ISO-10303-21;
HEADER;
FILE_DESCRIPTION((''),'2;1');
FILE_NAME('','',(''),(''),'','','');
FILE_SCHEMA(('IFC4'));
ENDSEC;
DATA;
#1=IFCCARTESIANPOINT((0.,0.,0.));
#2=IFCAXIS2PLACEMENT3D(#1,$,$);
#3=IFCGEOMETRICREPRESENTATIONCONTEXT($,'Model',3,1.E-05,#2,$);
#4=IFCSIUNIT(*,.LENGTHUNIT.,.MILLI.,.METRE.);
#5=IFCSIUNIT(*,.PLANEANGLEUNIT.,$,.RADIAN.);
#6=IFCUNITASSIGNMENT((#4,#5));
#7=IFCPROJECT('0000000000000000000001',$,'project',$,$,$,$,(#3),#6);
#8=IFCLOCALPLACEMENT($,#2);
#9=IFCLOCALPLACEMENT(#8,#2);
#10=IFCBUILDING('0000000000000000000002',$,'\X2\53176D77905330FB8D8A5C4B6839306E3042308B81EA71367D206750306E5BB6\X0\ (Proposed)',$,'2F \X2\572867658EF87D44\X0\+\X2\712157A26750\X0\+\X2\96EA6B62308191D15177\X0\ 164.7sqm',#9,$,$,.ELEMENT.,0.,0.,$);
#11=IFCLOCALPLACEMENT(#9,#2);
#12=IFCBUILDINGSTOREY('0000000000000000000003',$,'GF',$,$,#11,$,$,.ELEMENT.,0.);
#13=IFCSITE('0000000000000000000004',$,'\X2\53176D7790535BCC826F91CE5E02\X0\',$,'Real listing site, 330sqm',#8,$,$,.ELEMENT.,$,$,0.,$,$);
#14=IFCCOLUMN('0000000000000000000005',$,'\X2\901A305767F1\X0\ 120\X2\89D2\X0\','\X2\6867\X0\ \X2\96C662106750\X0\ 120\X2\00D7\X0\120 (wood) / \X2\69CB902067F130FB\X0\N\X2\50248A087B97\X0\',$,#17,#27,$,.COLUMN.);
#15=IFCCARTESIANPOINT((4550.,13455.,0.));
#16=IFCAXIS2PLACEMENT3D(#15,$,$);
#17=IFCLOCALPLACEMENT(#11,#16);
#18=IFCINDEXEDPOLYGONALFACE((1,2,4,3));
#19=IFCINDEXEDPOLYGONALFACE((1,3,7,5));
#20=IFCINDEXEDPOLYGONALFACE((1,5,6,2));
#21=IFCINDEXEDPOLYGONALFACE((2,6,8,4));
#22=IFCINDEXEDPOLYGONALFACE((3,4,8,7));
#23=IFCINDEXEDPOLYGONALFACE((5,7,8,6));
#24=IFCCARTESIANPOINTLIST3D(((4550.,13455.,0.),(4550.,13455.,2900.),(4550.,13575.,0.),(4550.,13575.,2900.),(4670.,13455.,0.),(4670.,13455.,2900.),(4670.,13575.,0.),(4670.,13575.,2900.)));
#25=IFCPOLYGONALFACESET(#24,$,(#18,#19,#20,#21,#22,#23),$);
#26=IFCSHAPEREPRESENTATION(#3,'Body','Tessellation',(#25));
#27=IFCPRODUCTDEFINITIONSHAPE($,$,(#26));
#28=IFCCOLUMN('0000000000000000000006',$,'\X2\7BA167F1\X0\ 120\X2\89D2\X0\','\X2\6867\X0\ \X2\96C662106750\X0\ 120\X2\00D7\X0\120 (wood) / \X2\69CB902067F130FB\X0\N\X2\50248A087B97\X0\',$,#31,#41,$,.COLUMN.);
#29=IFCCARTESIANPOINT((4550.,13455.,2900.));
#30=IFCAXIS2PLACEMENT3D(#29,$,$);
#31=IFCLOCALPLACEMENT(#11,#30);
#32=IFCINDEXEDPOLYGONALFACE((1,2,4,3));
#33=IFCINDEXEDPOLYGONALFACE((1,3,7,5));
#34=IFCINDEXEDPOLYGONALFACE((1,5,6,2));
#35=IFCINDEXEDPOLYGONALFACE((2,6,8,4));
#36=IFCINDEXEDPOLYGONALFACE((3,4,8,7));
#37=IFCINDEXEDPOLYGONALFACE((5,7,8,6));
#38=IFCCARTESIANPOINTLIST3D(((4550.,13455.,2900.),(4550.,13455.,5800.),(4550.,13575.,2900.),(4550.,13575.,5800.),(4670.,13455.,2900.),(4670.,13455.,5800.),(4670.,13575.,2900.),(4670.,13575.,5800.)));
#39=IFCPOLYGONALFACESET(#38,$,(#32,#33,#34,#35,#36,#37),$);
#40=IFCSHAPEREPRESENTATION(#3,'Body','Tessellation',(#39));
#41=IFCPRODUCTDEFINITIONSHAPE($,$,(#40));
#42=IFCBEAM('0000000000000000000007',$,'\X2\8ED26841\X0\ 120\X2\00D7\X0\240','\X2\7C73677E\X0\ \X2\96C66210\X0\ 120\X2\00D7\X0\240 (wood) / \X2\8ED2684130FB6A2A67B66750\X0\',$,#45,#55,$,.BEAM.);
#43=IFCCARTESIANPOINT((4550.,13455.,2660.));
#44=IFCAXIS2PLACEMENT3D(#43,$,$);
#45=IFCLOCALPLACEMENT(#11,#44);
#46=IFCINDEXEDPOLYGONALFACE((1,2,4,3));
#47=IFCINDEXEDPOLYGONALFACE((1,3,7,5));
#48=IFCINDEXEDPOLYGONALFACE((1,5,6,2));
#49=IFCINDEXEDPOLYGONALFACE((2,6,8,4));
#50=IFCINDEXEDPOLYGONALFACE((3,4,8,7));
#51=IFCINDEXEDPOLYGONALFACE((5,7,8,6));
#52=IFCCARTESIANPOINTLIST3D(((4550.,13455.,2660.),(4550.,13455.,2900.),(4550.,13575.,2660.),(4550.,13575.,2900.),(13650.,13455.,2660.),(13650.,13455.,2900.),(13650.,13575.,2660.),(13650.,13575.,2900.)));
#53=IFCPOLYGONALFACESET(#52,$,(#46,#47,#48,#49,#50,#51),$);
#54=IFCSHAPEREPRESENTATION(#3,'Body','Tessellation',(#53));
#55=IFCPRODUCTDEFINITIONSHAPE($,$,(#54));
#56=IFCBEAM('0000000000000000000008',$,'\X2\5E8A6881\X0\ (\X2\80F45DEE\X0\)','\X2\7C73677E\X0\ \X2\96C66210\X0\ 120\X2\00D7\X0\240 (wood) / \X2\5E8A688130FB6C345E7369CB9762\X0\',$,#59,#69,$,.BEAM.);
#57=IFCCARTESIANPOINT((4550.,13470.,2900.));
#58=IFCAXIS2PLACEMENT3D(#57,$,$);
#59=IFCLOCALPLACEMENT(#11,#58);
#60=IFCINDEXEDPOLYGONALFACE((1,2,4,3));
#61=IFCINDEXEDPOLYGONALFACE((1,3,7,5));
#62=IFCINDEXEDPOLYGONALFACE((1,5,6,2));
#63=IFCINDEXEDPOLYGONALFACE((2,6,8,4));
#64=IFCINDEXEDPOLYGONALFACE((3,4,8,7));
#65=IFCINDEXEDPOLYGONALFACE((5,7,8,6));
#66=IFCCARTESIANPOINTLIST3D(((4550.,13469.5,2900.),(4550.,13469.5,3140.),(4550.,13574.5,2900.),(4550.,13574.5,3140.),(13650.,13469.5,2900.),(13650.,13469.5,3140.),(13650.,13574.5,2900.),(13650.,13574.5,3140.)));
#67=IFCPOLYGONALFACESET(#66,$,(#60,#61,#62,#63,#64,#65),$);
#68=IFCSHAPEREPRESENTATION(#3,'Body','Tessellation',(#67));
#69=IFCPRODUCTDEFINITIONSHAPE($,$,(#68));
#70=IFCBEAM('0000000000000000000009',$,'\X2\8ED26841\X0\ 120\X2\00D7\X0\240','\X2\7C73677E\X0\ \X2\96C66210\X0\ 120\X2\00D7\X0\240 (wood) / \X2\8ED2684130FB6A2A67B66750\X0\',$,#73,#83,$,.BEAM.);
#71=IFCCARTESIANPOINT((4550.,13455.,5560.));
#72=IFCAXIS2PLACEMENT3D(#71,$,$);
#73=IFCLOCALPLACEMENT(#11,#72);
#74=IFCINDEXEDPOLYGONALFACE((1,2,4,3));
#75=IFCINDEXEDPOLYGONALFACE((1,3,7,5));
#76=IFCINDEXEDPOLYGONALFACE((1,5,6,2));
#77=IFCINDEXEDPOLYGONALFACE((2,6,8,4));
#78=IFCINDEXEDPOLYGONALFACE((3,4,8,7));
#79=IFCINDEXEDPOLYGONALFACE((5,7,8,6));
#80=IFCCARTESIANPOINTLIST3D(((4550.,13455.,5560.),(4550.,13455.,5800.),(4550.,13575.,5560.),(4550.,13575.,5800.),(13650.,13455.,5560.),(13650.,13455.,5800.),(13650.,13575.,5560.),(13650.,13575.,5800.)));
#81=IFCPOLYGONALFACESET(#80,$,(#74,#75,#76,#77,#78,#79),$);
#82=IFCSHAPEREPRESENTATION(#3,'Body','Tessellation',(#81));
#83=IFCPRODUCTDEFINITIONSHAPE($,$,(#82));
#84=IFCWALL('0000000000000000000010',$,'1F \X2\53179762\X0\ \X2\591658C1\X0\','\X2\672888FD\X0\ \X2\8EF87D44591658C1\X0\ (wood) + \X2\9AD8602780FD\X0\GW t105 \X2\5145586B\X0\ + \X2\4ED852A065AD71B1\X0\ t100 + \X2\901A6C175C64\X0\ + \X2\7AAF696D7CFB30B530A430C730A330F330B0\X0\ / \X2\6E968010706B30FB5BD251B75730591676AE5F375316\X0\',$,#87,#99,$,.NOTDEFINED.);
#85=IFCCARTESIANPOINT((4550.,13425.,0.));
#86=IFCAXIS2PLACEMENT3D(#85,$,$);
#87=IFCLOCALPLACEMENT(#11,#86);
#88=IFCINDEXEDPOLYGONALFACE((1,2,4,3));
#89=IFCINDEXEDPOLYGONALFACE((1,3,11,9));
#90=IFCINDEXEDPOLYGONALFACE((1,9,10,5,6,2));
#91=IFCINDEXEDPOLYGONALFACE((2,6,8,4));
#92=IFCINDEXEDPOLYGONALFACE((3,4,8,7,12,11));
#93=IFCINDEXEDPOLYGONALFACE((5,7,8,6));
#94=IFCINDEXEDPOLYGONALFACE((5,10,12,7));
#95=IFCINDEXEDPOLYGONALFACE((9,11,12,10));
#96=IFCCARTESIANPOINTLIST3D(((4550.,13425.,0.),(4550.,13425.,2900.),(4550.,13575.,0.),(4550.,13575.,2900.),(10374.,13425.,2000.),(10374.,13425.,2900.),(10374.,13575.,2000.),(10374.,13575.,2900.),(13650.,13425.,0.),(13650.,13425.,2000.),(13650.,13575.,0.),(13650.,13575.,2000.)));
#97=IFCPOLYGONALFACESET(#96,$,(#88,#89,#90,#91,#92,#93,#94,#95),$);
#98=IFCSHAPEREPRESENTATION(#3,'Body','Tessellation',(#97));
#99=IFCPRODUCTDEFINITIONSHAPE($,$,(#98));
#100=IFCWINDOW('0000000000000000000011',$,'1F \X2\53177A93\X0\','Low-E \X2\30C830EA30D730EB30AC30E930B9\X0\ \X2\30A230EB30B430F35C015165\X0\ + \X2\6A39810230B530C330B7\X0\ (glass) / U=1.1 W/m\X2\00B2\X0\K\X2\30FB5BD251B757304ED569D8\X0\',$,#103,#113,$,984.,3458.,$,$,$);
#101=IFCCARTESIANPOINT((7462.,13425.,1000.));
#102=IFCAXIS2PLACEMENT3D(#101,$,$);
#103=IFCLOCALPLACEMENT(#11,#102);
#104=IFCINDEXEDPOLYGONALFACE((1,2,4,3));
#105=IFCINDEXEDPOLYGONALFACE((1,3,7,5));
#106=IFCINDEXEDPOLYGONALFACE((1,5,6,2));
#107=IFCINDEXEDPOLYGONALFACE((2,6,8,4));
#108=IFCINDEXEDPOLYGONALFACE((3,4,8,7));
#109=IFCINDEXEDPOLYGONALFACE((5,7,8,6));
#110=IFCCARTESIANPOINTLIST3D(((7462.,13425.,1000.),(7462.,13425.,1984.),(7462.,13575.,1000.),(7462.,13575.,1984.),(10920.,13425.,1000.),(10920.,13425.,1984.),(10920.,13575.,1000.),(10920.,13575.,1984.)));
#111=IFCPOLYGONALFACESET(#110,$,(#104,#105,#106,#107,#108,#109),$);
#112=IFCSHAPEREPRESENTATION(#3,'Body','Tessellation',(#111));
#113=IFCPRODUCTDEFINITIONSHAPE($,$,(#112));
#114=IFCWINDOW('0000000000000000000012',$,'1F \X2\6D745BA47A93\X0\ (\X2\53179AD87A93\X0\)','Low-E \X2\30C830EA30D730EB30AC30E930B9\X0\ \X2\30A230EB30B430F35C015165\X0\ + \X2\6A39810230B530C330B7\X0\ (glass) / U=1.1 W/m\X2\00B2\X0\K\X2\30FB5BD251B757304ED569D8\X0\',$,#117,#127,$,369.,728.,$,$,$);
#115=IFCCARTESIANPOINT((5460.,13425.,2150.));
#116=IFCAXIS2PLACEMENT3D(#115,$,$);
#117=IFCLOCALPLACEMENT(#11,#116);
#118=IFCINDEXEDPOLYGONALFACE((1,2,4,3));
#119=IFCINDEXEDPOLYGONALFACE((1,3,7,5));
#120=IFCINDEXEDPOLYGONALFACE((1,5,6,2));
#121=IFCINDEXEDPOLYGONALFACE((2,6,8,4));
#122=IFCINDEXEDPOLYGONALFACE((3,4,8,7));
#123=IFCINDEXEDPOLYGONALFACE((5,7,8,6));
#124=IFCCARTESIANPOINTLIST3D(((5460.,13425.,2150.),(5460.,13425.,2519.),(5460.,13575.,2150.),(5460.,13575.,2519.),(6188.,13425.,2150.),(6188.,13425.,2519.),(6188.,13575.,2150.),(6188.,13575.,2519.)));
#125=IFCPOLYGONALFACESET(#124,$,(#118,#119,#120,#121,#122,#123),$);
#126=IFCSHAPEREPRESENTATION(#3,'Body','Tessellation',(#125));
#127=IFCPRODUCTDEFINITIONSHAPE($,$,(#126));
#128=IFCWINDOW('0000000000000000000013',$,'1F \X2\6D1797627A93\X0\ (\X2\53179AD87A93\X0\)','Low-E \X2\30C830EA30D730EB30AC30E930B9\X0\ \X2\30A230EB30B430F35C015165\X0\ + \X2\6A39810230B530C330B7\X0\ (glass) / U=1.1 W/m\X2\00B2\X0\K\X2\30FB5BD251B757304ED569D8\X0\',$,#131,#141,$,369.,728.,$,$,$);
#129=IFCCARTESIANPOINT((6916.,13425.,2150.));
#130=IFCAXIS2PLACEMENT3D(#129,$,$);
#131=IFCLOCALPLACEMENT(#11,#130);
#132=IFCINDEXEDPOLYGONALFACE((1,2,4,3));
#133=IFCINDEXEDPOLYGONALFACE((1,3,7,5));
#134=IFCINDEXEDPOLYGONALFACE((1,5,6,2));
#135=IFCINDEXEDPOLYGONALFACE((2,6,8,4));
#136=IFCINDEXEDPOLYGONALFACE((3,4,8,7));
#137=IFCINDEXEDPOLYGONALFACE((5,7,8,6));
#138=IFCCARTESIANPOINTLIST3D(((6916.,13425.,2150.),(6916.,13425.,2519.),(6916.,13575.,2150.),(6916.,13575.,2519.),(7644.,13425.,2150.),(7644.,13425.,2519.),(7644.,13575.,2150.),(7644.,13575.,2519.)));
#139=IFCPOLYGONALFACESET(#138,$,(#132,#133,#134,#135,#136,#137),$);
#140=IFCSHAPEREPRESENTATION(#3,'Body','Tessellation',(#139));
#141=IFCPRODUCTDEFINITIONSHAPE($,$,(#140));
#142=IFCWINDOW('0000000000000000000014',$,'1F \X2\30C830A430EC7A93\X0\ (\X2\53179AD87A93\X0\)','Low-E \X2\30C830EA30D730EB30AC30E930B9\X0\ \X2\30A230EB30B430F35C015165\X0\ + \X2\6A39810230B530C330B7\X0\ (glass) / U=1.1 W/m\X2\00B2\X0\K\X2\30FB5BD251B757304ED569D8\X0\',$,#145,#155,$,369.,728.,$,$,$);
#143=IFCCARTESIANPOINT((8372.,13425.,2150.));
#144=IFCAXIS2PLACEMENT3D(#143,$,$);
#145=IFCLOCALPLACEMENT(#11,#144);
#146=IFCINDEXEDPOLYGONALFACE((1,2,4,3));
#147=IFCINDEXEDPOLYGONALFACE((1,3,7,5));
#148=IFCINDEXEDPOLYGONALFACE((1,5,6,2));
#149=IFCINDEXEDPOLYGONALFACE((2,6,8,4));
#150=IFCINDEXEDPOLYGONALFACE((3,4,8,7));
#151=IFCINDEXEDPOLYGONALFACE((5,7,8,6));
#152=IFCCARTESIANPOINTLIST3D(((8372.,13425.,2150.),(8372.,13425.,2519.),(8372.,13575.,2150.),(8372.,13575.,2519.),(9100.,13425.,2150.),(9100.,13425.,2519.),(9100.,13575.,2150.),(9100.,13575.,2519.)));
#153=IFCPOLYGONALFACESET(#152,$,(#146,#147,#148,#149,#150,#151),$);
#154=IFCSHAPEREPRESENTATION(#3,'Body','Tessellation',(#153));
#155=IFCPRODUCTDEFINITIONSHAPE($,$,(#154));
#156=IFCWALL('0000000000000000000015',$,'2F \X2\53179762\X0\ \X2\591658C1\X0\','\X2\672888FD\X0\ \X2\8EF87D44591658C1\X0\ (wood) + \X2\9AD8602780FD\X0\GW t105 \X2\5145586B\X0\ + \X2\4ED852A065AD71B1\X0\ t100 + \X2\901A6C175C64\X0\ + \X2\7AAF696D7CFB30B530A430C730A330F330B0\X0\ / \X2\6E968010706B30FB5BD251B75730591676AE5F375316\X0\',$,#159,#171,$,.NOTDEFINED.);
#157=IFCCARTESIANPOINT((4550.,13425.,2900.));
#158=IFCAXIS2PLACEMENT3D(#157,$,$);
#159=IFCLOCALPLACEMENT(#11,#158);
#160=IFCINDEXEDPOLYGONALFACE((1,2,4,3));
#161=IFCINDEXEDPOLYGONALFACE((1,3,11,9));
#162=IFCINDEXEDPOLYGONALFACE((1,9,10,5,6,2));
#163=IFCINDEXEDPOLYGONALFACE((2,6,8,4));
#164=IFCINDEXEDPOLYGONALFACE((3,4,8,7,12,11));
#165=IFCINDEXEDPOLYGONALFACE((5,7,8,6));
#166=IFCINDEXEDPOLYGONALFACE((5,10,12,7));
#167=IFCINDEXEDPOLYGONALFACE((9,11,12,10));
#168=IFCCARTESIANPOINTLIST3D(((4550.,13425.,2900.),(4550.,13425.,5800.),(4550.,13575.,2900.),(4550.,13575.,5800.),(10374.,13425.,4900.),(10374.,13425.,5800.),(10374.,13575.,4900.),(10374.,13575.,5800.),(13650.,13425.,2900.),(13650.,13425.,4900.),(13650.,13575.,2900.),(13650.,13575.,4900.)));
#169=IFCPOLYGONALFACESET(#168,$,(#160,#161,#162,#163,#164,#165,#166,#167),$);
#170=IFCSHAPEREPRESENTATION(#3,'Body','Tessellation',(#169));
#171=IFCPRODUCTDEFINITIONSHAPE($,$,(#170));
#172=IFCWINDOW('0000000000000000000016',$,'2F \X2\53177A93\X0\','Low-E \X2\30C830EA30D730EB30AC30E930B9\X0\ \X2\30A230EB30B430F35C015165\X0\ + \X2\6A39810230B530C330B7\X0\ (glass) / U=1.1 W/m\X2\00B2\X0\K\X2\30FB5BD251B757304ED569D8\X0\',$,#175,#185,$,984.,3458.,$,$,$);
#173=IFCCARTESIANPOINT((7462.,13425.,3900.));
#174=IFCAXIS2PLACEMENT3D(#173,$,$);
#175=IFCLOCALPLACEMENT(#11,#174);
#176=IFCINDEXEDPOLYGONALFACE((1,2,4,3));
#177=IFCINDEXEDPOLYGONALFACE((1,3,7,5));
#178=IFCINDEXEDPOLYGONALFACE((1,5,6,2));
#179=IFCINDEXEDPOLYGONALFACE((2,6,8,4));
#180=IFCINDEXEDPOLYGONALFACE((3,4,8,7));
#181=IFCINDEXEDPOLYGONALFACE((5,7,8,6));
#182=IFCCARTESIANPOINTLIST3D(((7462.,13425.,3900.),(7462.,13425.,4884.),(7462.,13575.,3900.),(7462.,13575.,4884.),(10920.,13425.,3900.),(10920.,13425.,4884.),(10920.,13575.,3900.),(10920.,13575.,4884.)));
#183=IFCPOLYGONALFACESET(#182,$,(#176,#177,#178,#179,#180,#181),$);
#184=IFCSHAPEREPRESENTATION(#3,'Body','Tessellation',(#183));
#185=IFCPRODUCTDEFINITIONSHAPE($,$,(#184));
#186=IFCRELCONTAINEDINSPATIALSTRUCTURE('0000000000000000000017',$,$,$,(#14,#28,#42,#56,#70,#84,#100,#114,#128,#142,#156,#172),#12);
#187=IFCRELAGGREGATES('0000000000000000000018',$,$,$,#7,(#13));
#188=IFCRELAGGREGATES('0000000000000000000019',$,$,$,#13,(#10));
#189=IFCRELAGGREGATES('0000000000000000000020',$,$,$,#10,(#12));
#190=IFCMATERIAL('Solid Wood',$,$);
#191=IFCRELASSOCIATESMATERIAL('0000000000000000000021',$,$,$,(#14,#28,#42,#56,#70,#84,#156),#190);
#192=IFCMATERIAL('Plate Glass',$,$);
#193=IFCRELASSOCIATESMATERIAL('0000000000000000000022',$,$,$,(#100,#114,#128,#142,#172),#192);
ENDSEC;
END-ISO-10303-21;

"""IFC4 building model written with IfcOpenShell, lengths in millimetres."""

from ifc_helpers import new_model, si_unit, frame, frame_2d, origin, place, context, project, spatial, rectangle, extrude, material, element, fill, save


model = new_model("IFC4")

# Units and contexts
model_context = context("Model", 3, precision=1e-05, world=origin())
ifc_project = project(units=[si_unit("LENGTHUNIT", "METRE", prefix="MILLI"), si_unit("PLANEANGLEUNIT", "RADIAN")], contexts=[model_context])

# Site, building, storey
site_placement = place(None, origin())
site = spatial("IfcSite", under=ifc_project, at=site_placement, Name="北海道富良野市", ObjectType="Real listing site, 330sqm", CompositionType="ELEMENT", RefElevation=0.0)
building_placement = place(site_placement, origin())
building = spatial("IfcBuilding", under=site, at=building_placement, Name="北海道・越屋根のある自然素材の家 (Proposed)", ObjectType="2F 在来軸組+無垢材+雪止め金具 164.7sqm", CompositionType="ELEMENT", ElevationOfRefHeight=0.0, ElevationOfTerrain=0.0)
storey_placement = place(building_placement, origin())
storey = spatial("IfcBuildingStorey", under=building, at=storey_placement, Name="GF", CompositionType="ELEMENT", Elevation=0.0)

# Columns
ifc_material_1 = material(Name="Solid Wood")
column_1_placement = place(storey_placement, frame((4550.0, 13455.0, 0.0)))
element("IfcColumn", 1, at=column_1_placement, inside=storey, material=ifc_material_1, Name="通し柱 120角", Description="桧 集成材 120×120 (wood) / 構造柱・N値計算", PredefinedType="COLUMN", context=model_context, shape_type="SweptSolid", body=[
    extrude(rectangle(XDim=120.0, YDim=120.0, at=frame_2d((60.0, 60.0))), frame((4550.0, 13455.0, 0.0)), (0.0, 0.0, 1.0), 2900.0),
])
column_2_placement = place(storey_placement, frame((4550.0, 13455.0, 2900.0)))
element("IfcColumn", 2, at=column_2_placement, inside=storey, material=ifc_material_1, Name="管柱 120角", Description="桧 集成材 120×120 (wood) / 構造柱・N値計算", PredefinedType="COLUMN", context=model_context, shape_type="SweptSolid", body=[
    extrude(rectangle(XDim=120.0, YDim=120.0, at=frame_2d((60.0, 60.0))), frame((4550.0, 13455.0, 2900.0)), (0.0, 0.0, 1.0), 2900.0),
])

# Beams
beam_1_placement = place(storey_placement, frame((4550.0, 13455.0, 2660.0)))
element("IfcBeam", 3, at=beam_1_placement, inside=storey, material=ifc_material_1, Name="軒桁 120×240", Description="米松 集成 120×240 (wood) / 軒桁・横架材", PredefinedType="BEAM", context=model_context, shape_type="SweptSolid", body=[
    extrude(rectangle(XDim=9100.0, YDim=120.0, at=frame_2d((4550.0, 60.0))), frame((4550.0, 13455.0, 2660.0)), (0.0, 0.0, 1.0), 240.0),
])
beam_2_placement = place(storey_placement, frame((4550.0, 13470.0, 2900.0)))
element("IfcBeam", 4, at=beam_2_placement, inside=storey, material=ifc_material_1, Name="床梁 (胴差)", Description="米松 集成 120×240 (wood) / 床梁・水平構面", PredefinedType="BEAM", context=model_context, shape_type="SweptSolid", body=[
    extrude(rectangle(XDim=9100.0, YDim=105.0, at=frame_2d((4550.0, 52.0))), frame((4550.0, 13470.0, 2900.0)), (0.0, 0.0, 1.0), 240.0),
])
beam_3_placement = place(storey_placement, frame((4550.0, 13455.0, 5560.0)))
element("IfcBeam", 5, at=beam_3_placement, inside=storey, material=ifc_material_1, Name="軒桁 120×240", Description="米松 集成 120×240 (wood) / 軒桁・横架材", PredefinedType="BEAM", context=model_context, shape_type="SweptSolid", body=[
    extrude(rectangle(XDim=9100.0, YDim=120.0, at=frame_2d((4550.0, 60.0))), frame((4550.0, 13455.0, 5560.0)), (0.0, 0.0, 1.0), 240.0),
])

# Wall, openings, windows
wall_1_placement = place(storey_placement, frame((4550.0, 13425.0, 0.0)))
wall_1 = element("IfcWall", 6, at=wall_1_placement, inside=storey, material=ifc_material_1, Name="1F 北面 外壁", Description="木製 軸組外壁 (wood) + 高性能GW t105 充填 + 付加断熱 t100 + 通気層 + 窯業系サイディング / 準耐火・寒冷地外皮強化", PredefinedType="NOTDEFINED", context=model_context, shape_type="SweptSolid", body=[
    extrude(rectangle(XDim=9100.0, YDim=150.0, at=frame_2d((4550.0, 75.0))), frame((4550.0, 13425.0, 0.0)), (0.0, 0.0, 1.0), 2900.0),
])
opening_1_placement = place(storey_placement, frame((7462.0, 13425.0, 1000.0)))
opening_1 = element("IfcOpeningElement", 7, at=opening_1_placement, cuts=wall_1, PredefinedType="NOTDEFINED", context=model_context, shape_type="SweptSolid", body=[
    extrude(rectangle(XDim=3458.0, YDim=150.0, at=frame_2d((1729.0, 75.0))), frame((7462.0, 13425.0, 1000.0)), (0.0, 0.0, 1.0), 984.0),
])
opening_2_placement = place(storey_placement, frame((5460.0, 13425.0, 2150.0)))
opening_2 = element("IfcOpeningElement", 8, at=opening_2_placement, cuts=wall_1, PredefinedType="NOTDEFINED", context=model_context, shape_type="SweptSolid", body=[
    extrude(rectangle(XDim=728.0, YDim=150.0, at=frame_2d((364.0, 75.0))), frame((5460.0, 13425.0, 2150.0)), (0.0, 0.0, 1.0), 369.0),
])
opening_3_placement = place(storey_placement, frame((6916.0, 13425.0, 2150.0)))
opening_3 = element("IfcOpeningElement", 9, at=opening_3_placement, cuts=wall_1, PredefinedType="NOTDEFINED", context=model_context, shape_type="SweptSolid", body=[
    extrude(rectangle(XDim=728.0, YDim=150.0, at=frame_2d((364.0, 75.0))), frame((6916.0, 13425.0, 2150.0)), (0.0, 0.0, 1.0), 369.0),
])
opening_4_placement = place(storey_placement, frame((8372.0, 13425.0, 2150.0)))
opening_4 = element("IfcOpeningElement", 10, at=opening_4_placement, cuts=wall_1, PredefinedType="NOTDEFINED", context=model_context, shape_type="SweptSolid", body=[
    extrude(rectangle(XDim=728.0, YDim=150.0, at=frame_2d((364.0, 75.0))), frame((8372.0, 13425.0, 2150.0)), (0.0, 0.0, 1.0), 369.0),
])
ifc_material_2 = material(Name="Plate Glass")
window_1_placement = place(storey_placement, frame((7462.0, 13425.0, 1000.0)))
window_1 = element("IfcWindow", 11, at=window_1_placement, inside=storey, material=ifc_material_2, Name="1F 北窓", Description="Low-E トリプルガラス アルゴン封入 + 樹脂サッシ (glass) / U=1.1 W/m²K・寒冷地仕様", OverallHeight=984.0, OverallWidth=3458.0, context=model_context, shape_type="SweptSolid", body=[
    extrude(rectangle(XDim=3458.0, YDim=150.0, at=frame_2d((1729.0, 75.0))), frame((7462.0, 13425.0, 1000.0)), (0.0, 0.0, 1.0), 984.0),
])
fill(opening_1, window_1)
window_2_placement = place(storey_placement, frame((5460.0, 13425.0, 2150.0)))
window_2 = element("IfcWindow", 12, at=window_2_placement, inside=storey, material=ifc_material_2, Name="1F 浴室窓 (北高窓)", Description="Low-E トリプルガラス アルゴン封入 + 樹脂サッシ (glass) / U=1.1 W/m²K・寒冷地仕様", OverallHeight=369.0, OverallWidth=728.0, context=model_context, shape_type="SweptSolid", body=[
    extrude(rectangle(XDim=728.0, YDim=150.0, at=frame_2d((364.0, 75.0))), frame((5460.0, 13425.0, 2150.0)), (0.0, 0.0, 1.0), 369.0),
])
fill(opening_2, window_2)
window_3_placement = place(storey_placement, frame((6916.0, 13425.0, 2150.0)))
window_3 = element("IfcWindow", 13, at=window_3_placement, inside=storey, material=ifc_material_2, Name="1F 洗面窓 (北高窓)", Description="Low-E トリプルガラス アルゴン封入 + 樹脂サッシ (glass) / U=1.1 W/m²K・寒冷地仕様", OverallHeight=369.0, OverallWidth=728.0, context=model_context, shape_type="SweptSolid", body=[
    extrude(rectangle(XDim=728.0, YDim=150.0, at=frame_2d((364.0, 75.0))), frame((6916.0, 13425.0, 2150.0)), (0.0, 0.0, 1.0), 369.0),
])
fill(opening_3, window_3)
window_4_placement = place(storey_placement, frame((8372.0, 13425.0, 2150.0)))
window_4 = element("IfcWindow", 14, at=window_4_placement, inside=storey, material=ifc_material_2, Name="1F トイレ窓 (北高窓)", Description="Low-E トリプルガラス アルゴン封入 + 樹脂サッシ (glass) / U=1.1 W/m²K・寒冷地仕様", OverallHeight=369.0, OverallWidth=728.0, context=model_context, shape_type="SweptSolid", body=[
    extrude(rectangle(XDim=728.0, YDim=150.0, at=frame_2d((364.0, 75.0))), frame((8372.0, 13425.0, 2150.0)), (0.0, 0.0, 1.0), 369.0),
])
fill(opening_4, window_4)

# Wall, opening, window
wall_2_placement = place(storey_placement, frame((4550.0, 13425.0, 2900.0)))
wall_2 = element("IfcWall", 15, at=wall_2_placement, inside=storey, material=ifc_material_1, Name="2F 北面 外壁", Description="木製 軸組外壁 (wood) + 高性能GW t105 充填 + 付加断熱 t100 + 通気層 + 窯業系サイディング / 準耐火・寒冷地外皮強化", PredefinedType="NOTDEFINED", context=model_context, shape_type="SweptSolid", body=[
    extrude(rectangle(XDim=9100.0, YDim=150.0, at=frame_2d((4550.0, 75.0))), frame((4550.0, 13425.0, 2900.0)), (0.0, 0.0, 1.0), 2900.0),
])
opening_5_placement = place(storey_placement, frame((7462.0, 13425.0, 3900.0)))
opening_5 = element("IfcOpeningElement", 16, at=opening_5_placement, cuts=wall_2, PredefinedType="NOTDEFINED", context=model_context, shape_type="SweptSolid", body=[
    extrude(rectangle(XDim=3458.0, YDim=150.0, at=frame_2d((1729.0, 75.0))), frame((7462.0, 13425.0, 3900.0)), (0.0, 0.0, 1.0), 984.0),
])
window_5_placement = place(storey_placement, frame((7462.0, 13425.0, 3900.0)))
window_5 = element("IfcWindow", 17, at=window_5_placement, inside=storey, material=ifc_material_2, Name="2F 北窓", Description="Low-E トリプルガラス アルゴン封入 + 樹脂サッシ (glass) / U=1.1 W/m²K・寒冷地仕様", OverallHeight=984.0, OverallWidth=3458.0, context=model_context, shape_type="SweptSolid", body=[
    extrude(rectangle(XDim=3458.0, YDim=150.0, at=frame_2d((1729.0, 75.0))), frame((7462.0, 13425.0, 3900.0)), (0.0, 0.0, 1.0), 984.0),
])
fill(opening_5, window_5)

save(model, "model.ifc")
